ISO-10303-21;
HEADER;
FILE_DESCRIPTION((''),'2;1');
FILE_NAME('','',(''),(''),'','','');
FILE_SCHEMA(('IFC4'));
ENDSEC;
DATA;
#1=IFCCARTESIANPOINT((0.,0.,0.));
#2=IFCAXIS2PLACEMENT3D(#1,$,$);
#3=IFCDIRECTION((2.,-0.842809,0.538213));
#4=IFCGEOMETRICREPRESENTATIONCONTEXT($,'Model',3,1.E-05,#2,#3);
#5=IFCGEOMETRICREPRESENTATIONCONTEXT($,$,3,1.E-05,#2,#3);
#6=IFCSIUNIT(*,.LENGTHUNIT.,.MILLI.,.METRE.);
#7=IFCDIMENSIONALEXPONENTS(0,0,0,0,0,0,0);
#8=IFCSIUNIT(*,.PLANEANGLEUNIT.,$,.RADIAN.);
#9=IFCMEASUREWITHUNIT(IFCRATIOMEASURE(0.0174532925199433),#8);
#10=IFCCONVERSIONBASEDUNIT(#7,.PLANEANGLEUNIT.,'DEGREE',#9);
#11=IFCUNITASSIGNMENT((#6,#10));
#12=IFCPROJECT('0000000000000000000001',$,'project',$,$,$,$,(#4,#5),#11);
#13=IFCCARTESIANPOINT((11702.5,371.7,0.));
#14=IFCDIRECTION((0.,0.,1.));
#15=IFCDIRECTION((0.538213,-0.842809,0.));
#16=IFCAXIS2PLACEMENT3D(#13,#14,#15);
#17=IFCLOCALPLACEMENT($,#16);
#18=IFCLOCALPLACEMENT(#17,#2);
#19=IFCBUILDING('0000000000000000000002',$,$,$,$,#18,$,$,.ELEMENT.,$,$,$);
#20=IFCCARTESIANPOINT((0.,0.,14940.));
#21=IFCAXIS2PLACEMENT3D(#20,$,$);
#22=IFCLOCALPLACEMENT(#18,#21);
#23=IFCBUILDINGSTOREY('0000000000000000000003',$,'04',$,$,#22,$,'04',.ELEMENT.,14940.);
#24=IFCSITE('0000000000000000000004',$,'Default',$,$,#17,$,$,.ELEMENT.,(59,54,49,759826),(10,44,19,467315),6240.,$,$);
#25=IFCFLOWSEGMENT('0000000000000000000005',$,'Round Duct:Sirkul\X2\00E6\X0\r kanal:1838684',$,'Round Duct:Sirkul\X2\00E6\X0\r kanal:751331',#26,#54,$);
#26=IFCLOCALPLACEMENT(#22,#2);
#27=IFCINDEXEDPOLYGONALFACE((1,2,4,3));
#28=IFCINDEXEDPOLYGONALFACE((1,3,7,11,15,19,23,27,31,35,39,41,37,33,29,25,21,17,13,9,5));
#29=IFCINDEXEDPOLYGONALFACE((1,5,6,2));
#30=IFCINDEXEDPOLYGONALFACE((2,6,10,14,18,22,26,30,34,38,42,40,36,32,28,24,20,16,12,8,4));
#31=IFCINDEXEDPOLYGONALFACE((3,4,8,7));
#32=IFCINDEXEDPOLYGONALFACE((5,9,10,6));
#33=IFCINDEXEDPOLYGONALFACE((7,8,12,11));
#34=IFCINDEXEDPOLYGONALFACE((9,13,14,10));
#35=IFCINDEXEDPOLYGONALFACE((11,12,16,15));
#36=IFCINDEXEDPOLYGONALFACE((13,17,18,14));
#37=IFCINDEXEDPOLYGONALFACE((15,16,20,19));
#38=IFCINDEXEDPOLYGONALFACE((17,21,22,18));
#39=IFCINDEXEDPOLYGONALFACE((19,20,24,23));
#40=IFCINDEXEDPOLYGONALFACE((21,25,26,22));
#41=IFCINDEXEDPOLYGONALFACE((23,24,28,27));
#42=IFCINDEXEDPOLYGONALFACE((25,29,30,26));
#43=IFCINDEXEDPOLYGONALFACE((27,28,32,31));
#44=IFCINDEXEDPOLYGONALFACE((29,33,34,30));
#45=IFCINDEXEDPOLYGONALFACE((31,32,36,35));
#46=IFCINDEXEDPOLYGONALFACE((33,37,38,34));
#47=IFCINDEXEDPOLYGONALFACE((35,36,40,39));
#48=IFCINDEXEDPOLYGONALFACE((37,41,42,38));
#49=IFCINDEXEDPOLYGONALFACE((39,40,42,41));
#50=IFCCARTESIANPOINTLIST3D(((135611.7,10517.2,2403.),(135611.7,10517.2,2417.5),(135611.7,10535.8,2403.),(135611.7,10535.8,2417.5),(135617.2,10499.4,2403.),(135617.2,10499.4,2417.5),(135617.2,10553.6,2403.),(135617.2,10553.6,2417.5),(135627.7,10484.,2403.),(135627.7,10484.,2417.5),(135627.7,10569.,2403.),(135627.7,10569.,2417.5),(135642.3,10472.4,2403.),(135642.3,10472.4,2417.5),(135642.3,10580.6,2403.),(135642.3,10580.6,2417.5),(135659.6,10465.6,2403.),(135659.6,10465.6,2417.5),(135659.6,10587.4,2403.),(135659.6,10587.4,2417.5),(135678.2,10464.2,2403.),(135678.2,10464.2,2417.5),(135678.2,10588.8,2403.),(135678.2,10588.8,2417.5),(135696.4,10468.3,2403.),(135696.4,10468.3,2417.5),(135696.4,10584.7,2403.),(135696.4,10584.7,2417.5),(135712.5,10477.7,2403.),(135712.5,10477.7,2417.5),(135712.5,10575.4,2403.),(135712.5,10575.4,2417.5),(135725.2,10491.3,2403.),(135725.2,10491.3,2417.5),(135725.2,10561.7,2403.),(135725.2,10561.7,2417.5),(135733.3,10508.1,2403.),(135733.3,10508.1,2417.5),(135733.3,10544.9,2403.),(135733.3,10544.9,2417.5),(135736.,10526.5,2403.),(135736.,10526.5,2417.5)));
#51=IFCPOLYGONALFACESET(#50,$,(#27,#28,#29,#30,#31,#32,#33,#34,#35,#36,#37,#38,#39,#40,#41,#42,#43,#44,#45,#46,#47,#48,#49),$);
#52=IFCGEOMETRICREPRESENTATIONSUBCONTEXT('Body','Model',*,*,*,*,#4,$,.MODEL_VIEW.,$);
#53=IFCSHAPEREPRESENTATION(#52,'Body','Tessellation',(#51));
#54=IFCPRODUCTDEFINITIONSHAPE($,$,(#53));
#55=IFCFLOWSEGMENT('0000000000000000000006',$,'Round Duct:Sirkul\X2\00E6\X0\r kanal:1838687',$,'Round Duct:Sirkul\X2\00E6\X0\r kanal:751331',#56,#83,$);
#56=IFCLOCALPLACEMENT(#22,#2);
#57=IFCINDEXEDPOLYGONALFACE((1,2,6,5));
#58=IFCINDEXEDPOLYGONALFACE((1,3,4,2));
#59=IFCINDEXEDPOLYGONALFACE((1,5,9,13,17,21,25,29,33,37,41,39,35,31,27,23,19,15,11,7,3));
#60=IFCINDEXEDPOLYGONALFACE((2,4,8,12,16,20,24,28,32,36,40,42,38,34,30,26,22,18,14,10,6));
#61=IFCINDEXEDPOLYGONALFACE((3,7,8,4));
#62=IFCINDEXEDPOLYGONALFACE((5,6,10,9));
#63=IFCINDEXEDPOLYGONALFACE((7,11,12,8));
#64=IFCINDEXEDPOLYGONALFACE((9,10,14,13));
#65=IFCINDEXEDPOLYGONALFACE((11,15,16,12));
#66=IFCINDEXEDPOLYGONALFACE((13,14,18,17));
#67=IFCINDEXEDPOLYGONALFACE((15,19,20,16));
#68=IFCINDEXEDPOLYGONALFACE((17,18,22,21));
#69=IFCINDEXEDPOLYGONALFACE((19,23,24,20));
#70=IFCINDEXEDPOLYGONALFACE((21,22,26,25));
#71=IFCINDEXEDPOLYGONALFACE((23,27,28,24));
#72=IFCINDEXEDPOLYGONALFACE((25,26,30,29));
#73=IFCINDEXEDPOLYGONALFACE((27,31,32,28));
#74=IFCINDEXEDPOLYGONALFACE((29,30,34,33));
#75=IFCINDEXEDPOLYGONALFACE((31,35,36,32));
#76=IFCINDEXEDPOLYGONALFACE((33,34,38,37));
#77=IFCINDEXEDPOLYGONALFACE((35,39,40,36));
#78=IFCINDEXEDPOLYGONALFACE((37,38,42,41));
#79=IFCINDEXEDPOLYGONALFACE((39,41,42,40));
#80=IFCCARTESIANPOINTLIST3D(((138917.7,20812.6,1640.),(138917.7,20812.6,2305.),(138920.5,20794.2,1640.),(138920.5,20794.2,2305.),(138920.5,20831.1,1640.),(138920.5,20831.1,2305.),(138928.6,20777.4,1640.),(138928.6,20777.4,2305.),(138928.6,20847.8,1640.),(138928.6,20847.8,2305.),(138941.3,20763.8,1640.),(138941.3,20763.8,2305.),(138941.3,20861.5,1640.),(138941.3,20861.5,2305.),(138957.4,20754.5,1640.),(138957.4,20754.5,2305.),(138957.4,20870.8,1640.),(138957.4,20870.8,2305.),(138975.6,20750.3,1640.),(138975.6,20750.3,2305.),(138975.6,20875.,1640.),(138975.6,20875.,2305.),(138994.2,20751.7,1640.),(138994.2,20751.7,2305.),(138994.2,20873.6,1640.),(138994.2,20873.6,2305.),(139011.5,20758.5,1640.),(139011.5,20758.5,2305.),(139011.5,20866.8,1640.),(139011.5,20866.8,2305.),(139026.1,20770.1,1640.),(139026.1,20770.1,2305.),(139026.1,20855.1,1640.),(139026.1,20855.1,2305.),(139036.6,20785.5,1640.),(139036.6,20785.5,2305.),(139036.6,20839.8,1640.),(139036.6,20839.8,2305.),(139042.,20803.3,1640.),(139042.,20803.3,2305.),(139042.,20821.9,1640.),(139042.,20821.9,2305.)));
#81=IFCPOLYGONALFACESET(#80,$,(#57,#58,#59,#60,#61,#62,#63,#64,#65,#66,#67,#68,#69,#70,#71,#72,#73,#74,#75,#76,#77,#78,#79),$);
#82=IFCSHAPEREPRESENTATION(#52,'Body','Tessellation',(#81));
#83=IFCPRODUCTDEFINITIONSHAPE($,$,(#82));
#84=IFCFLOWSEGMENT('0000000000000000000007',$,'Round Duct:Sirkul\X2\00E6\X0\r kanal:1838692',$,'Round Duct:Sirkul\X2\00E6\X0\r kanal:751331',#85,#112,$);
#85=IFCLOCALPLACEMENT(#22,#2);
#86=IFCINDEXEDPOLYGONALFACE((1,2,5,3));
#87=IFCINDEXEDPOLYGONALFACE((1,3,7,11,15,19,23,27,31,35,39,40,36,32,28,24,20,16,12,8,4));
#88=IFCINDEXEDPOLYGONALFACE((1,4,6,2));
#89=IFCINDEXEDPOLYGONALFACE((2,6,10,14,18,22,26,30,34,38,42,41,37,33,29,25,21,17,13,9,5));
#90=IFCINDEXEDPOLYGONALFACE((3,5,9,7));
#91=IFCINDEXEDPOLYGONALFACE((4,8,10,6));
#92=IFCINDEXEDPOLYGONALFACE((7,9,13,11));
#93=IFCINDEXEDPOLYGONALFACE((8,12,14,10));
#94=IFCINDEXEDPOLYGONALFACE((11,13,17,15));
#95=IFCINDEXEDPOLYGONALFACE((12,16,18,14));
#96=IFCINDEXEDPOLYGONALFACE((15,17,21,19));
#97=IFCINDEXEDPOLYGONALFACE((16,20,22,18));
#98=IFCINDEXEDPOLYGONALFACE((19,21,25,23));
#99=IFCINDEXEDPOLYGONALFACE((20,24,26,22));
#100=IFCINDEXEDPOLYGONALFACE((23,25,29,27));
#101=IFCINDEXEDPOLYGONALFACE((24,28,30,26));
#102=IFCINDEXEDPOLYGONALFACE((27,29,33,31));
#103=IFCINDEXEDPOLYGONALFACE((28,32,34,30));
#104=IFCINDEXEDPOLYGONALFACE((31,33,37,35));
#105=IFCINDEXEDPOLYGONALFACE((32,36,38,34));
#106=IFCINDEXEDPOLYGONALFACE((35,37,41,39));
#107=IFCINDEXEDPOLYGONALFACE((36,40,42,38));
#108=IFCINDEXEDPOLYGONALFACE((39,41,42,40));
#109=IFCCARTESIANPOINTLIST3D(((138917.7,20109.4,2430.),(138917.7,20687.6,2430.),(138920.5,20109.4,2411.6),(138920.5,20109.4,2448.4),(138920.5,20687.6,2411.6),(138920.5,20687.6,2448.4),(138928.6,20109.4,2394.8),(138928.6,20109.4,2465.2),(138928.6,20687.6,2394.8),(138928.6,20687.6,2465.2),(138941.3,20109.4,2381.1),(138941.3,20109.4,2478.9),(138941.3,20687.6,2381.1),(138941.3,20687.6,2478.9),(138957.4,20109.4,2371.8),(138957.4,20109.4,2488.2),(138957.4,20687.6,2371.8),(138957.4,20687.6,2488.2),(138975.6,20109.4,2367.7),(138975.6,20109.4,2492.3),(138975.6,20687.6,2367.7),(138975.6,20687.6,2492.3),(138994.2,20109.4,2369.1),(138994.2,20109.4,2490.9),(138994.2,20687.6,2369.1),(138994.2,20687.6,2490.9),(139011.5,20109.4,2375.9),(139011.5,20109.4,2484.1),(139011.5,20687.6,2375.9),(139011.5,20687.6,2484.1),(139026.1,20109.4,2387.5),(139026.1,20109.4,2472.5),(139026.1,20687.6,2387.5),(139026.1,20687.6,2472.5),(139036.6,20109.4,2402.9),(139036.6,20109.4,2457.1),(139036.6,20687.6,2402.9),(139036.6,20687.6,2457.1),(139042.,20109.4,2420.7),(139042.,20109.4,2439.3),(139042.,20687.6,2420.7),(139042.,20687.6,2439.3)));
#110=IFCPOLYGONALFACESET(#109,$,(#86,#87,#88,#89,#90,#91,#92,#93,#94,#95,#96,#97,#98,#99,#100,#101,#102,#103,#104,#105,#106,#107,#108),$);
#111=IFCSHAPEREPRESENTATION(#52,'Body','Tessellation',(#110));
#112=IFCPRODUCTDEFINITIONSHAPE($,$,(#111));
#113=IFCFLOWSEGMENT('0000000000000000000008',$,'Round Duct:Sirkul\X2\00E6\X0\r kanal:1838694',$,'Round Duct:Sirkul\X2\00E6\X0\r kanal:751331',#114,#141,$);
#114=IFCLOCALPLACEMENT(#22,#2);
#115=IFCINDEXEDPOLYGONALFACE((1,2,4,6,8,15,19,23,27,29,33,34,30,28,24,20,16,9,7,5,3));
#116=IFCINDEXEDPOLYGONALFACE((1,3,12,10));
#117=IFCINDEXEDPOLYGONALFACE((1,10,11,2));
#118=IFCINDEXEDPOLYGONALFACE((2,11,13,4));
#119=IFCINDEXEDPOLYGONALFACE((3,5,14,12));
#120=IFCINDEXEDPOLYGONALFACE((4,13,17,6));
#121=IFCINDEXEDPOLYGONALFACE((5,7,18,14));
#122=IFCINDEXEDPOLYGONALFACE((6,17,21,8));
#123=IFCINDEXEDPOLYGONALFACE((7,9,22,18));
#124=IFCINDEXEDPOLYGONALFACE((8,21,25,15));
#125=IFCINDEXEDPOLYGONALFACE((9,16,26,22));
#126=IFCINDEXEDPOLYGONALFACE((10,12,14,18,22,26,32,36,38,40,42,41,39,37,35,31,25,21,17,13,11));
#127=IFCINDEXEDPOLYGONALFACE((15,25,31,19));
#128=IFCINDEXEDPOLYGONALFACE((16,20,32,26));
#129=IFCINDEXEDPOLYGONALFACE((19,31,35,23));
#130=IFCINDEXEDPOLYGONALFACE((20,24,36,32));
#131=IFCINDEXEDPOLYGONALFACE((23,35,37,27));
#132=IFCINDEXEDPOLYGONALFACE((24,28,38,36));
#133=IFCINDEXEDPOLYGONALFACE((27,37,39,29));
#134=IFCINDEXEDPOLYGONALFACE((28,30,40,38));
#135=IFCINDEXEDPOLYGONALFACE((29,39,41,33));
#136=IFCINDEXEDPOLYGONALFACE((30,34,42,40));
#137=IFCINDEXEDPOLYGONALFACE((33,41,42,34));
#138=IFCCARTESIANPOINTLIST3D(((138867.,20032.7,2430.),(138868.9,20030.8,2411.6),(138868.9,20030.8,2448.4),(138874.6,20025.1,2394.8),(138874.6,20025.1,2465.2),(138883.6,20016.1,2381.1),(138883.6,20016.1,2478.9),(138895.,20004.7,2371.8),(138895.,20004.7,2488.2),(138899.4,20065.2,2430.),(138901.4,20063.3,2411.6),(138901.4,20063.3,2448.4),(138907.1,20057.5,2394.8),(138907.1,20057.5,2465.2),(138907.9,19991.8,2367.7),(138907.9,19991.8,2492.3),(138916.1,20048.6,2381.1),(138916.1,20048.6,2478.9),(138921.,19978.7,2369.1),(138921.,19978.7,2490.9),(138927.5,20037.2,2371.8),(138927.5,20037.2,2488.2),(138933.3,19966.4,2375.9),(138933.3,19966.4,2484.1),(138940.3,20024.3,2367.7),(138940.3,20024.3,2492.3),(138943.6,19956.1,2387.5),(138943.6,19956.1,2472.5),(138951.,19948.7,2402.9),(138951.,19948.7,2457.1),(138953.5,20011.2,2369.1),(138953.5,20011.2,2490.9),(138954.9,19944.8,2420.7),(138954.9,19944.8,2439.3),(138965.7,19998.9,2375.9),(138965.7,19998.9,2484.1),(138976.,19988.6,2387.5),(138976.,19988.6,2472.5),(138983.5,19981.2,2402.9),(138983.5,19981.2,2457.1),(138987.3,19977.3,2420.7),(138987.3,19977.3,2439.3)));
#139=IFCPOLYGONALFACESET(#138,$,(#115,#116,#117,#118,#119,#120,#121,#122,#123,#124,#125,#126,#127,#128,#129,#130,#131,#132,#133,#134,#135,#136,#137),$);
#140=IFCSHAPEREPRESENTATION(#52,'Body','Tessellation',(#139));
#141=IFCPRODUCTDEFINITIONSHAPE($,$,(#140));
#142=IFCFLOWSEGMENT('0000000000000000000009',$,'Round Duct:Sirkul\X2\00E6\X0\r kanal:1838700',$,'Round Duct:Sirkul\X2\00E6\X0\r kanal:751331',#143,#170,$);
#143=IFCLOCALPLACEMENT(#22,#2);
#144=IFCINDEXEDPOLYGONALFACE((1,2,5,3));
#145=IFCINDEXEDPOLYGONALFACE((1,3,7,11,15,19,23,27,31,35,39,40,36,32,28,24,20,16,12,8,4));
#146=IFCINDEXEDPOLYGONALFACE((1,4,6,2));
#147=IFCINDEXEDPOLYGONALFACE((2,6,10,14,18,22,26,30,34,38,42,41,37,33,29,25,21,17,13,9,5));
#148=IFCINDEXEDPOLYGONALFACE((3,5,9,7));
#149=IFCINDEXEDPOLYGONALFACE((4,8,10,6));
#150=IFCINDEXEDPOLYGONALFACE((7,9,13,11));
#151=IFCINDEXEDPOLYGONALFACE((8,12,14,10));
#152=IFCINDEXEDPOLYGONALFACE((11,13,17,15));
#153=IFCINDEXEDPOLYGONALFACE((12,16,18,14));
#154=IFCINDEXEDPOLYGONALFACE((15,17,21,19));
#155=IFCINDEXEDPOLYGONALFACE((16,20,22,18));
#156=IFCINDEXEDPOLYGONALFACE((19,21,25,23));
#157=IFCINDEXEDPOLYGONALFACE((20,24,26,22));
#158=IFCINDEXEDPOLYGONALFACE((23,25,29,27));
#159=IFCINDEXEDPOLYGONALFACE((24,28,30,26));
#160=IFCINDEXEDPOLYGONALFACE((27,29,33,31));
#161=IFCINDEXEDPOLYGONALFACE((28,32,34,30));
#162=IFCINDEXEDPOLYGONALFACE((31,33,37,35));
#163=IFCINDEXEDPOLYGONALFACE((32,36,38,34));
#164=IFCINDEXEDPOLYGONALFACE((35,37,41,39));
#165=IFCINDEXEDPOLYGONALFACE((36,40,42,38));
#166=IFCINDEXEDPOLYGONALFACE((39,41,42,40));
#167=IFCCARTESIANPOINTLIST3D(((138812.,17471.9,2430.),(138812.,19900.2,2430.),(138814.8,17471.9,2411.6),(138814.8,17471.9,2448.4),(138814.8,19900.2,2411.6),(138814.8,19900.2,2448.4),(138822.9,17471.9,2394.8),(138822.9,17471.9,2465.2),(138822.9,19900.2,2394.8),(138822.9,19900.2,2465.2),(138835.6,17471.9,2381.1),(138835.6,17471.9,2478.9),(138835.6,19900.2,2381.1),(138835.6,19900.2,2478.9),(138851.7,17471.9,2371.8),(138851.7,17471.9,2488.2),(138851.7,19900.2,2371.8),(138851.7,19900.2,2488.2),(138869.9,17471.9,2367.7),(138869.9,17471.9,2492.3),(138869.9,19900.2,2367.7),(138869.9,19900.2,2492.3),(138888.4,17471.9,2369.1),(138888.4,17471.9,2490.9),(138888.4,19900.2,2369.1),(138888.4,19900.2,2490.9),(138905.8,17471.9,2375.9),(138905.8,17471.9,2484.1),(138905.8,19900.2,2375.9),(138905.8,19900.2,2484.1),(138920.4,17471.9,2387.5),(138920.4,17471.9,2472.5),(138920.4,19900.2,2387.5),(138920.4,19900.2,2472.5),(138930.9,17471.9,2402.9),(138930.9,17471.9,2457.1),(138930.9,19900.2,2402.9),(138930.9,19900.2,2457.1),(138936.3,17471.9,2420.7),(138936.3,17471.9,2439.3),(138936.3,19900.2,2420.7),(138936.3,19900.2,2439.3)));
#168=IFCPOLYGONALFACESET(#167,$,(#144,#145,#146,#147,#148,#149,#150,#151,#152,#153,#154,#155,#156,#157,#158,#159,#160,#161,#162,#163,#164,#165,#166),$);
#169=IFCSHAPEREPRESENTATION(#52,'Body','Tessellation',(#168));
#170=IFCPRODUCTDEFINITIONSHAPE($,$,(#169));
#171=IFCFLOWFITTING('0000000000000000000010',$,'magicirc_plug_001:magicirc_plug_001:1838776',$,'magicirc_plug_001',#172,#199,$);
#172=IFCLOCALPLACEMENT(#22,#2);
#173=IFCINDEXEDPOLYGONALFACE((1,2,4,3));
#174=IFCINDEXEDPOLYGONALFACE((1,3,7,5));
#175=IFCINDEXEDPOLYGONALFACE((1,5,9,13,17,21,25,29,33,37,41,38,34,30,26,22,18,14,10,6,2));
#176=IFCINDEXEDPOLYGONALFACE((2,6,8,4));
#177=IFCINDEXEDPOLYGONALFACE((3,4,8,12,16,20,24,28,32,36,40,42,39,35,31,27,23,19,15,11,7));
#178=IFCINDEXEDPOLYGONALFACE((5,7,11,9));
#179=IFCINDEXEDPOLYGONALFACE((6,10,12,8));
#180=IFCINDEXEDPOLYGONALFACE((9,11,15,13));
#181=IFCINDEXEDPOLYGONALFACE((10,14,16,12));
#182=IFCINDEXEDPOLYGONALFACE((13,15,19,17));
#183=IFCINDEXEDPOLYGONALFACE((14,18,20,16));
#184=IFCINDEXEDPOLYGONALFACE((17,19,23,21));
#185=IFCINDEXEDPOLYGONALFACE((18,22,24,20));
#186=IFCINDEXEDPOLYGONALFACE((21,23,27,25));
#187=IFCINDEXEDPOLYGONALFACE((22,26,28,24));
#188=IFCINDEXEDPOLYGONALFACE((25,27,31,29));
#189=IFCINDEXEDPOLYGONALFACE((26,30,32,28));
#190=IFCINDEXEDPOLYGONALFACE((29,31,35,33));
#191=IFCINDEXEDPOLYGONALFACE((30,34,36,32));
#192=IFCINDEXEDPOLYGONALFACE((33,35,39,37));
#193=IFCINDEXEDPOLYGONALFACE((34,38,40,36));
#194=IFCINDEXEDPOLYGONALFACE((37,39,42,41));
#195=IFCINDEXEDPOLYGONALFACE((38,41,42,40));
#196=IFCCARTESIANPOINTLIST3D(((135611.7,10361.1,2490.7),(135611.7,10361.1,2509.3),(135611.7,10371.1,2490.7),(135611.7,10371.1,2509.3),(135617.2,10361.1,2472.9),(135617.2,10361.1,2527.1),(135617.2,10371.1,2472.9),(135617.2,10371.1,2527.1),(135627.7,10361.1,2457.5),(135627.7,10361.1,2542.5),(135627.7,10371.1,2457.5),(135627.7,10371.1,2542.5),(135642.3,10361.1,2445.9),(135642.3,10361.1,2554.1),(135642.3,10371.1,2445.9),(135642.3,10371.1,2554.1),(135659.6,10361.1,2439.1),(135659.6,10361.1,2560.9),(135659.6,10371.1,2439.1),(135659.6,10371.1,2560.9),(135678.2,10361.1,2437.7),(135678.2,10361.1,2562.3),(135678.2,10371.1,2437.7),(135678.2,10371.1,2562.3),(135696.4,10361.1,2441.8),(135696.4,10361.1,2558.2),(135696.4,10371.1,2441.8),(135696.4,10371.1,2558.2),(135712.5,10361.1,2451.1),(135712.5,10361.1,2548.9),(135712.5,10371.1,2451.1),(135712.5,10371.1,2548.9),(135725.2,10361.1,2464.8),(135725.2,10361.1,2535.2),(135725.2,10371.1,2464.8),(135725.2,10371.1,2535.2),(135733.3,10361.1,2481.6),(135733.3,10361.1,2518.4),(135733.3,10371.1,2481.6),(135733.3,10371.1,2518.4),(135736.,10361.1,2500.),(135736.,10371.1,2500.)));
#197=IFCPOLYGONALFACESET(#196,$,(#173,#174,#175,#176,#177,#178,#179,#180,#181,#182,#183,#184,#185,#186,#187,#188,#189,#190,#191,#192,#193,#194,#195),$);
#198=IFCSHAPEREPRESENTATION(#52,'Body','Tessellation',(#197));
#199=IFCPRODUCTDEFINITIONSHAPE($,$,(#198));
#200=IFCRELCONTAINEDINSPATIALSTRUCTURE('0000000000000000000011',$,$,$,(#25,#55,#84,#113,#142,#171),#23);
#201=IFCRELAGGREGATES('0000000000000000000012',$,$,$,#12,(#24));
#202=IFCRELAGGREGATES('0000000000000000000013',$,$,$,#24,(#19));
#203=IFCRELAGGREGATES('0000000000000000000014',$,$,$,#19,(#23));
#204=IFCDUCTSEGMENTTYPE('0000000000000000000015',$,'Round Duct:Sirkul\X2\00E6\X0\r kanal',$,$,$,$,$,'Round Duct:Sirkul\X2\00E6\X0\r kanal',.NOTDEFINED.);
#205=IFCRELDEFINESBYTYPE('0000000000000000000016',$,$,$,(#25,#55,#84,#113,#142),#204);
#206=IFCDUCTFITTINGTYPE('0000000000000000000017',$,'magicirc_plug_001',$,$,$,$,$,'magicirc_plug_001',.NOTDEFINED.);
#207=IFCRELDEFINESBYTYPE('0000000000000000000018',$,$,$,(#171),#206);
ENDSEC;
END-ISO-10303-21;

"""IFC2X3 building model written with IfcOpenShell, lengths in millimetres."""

from ifc_helpers import new_model, entity, si_unit, converted_unit, direction, frame, frame_2d, origin, origin_2d_with_axis, place, context, subcontext, project, spatial, circle, extrude, source, transform, mapped, type_object, type_shapes, element, save


model = new_model("IFC2X3")

# Units and contexts
model_context = context("Model", 3, precision=1e-05, world=origin(), true_north=direction((2.0, -0.842809, 0.538213)))
context_of_model = context(None, 3, precision=1e-05, world=origin(), true_north=direction((2.0, -0.842809, 0.538213)))
body_context = subcontext(model_context, "Body", "Model", "MODEL_VIEW")
ifc_project = project(units=[si_unit("LENGTHUNIT", "METRE", prefix="MILLI"), converted_unit("PLANEANGLEUNIT", "DEGREE", entity("IfcRatioMeasure", 0.0174532925199433), si_unit("PLANEANGLEUNIT", "RADIAN"), dimensions=[0, 0, 0, 0, 0, 0, 0])], contexts=[model_context, context_of_model])

# Site, building, storey
site_placement = place(None, frame((11702.5, 371.7, 0.0), z_axis=(0.0, 0.0, 1.0), x_axis=(0.538213, -0.842809, 0.0)))
site = spatial("IfcSite", under=ifc_project, at=site_placement, Name="Default", CompositionType="ELEMENT", RefLatitude=(59, 54, 49, 759826), RefLongitude=(10, 44, 19, 467315), RefElevation=6240.0)
building_placement = place(site_placement, origin())
building = spatial("IfcBuilding", under=site, at=building_placement, CompositionType="ELEMENT")
storey_placement = place(building_placement, frame((0.0, 0.0, 14940.0)))
storey = spatial("IfcBuildingStorey", under=building, at=storey_placement, Name="04", LongName="04", CompositionType="ELEMENT", Elevation=14940.0)

# Flow segments
duct_segment_type = type_object("IfcDuctSegmentType", Name="Round Duct:Sirkulær kanal", ElementType="Round Duct:Sirkulær kanal", PredefinedType="NOTDEFINED")
flow_segment_1_placement = place(storey_placement, origin())
element("IfcFlowSegment", 1, at=flow_segment_1_placement, inside=storey, type_object=duct_segment_type, Name="Round Duct:Sirkulær kanal:1838684", ObjectType="Round Duct:Sirkulær kanal:751331", context=body_context, shape_type="SweptSolid", body=[
    extrude(circle(Radius=62.5, at=frame_2d((0.0, 0.0), x_axis=(1.0, 0.0))), frame((135673.5, 10526.5, 2403.0)), (0.0, 0.0, 1.0), 14.5),
])
flow_segment_2_placement = place(storey_placement, origin())
element("IfcFlowSegment", 2, at=flow_segment_2_placement, inside=storey, type_object=duct_segment_type, Name="Round Duct:Sirkulær kanal:1838687", ObjectType="Round Duct:Sirkulær kanal:751331", context=body_context, shape_type="SweptSolid", body=[
    extrude(circle(Radius=62.5, at=frame_2d((0.0, 0.0), x_axis=(1.0, 0.0))), frame((138980.2, 20812.6, 1640.0), z_axis=(0.0, 0.0, 1.0), x_axis=(-1.0, 0.0, 0.0)), (0.0, 0.0, 1.0), 665.0),
])
flow_segment_3_placement = place(storey_placement, origin())
element("IfcFlowSegment", 3, at=flow_segment_3_placement, inside=storey, type_object=duct_segment_type, Name="Round Duct:Sirkulær kanal:1838692", ObjectType="Round Duct:Sirkulær kanal:751331", context=body_context, shape_type="SweptSolid", body=[
    extrude(circle(Radius=62.5, at=origin_2d_with_axis()), frame((138980.2, 20109.4, 2430.0), z_axis=(0.0, 1.0, 0.0), x_axis=(-1.0, 0.0, 0.0)), (0.0, 0.0, 1.0), 578.2),
])
flow_segment_4_placement = place(storey_placement, origin())
element("IfcFlowSegment", 4, at=flow_segment_4_placement, inside=storey, type_object=duct_segment_type, Name="Round Duct:Sirkulær kanal:1838694", ObjectType="Round Duct:Sirkulær kanal:751331", context=body_context, shape_type="SweptSolid", body=[
    extrude(circle(Radius=62.5, at=frame_2d((0.0, 0.0), x_axis=(1.0, 0.0))), frame((138911.2, 19988.5, 2430.0), z_axis=(0.707107, 0.707107, 0.0), x_axis=(-0.707107, 0.707107, 0.0)), (0.0, 0.0, 1.0), 45.9),
])
flow_segment_5_placement = place(storey_placement, origin())
element("IfcFlowSegment", 5, at=flow_segment_5_placement, inside=storey, type_object=duct_segment_type, Name="Round Duct:Sirkulær kanal:1838700", ObjectType="Round Duct:Sirkulær kanal:751331", context=body_context, shape_type="SweptSolid", body=[
    extrude(circle(Radius=62.5, at=frame_2d((0.0, 0.0), x_axis=(1.0, 0.0))), frame((138874.5, 17471.9, 2430.0), z_axis=(0.0, 1.0, 0.0), x_axis=(-1.0, 0.0, 0.0)), (0.0, 0.0, 1.0), 2428.2),
])

# Flow fitting
duct_fitting_type_1 = type_object("IfcDuctFittingType", Name="magicirc_plug_001", ElementType="magicirc_plug_001", PredefinedType="NOTDEFINED")
shared_shape_1 = source(origin(), body_context, "Body", "SweptSolid", [
    extrude(circle(Radius=62.5, at=frame_2d((0.0, 0.0), x_axis=(1.0, 0.0))), frame((0.0, 0.0, 0.0), z_axis=(1.0, 0.0, 0.0), x_axis=(0.0, 1.0, 0.0)), (0.0, 0.0, 1.0), 10.0),
])
type_shapes(duct_fitting_type_1, [shared_shape_1])
for number, where, z_axis, x_axis, name in (
    (6, (135673.5, 10371.1, 2500.0), (0.0, 0.0, 1.0), (0.0, -1.0, 0.0), "magicirc_plug_001:magicirc_plug_001:1838776"),
):
    element("IfcFlowFitting", number, at=place(storey_placement, frame(where, z_axis=z_axis, x_axis=x_axis)), inside=storey, type_object=duct_fitting_type_1, Name=name, ObjectType="magicirc_plug_001", context=body_context, shape_type="MappedRepresentation", body=[
        mapped(shared_shape_1, transform((0.0, 0.0, 0.0), scale=1.0)),
    ])

save(model, "model.ifc")
